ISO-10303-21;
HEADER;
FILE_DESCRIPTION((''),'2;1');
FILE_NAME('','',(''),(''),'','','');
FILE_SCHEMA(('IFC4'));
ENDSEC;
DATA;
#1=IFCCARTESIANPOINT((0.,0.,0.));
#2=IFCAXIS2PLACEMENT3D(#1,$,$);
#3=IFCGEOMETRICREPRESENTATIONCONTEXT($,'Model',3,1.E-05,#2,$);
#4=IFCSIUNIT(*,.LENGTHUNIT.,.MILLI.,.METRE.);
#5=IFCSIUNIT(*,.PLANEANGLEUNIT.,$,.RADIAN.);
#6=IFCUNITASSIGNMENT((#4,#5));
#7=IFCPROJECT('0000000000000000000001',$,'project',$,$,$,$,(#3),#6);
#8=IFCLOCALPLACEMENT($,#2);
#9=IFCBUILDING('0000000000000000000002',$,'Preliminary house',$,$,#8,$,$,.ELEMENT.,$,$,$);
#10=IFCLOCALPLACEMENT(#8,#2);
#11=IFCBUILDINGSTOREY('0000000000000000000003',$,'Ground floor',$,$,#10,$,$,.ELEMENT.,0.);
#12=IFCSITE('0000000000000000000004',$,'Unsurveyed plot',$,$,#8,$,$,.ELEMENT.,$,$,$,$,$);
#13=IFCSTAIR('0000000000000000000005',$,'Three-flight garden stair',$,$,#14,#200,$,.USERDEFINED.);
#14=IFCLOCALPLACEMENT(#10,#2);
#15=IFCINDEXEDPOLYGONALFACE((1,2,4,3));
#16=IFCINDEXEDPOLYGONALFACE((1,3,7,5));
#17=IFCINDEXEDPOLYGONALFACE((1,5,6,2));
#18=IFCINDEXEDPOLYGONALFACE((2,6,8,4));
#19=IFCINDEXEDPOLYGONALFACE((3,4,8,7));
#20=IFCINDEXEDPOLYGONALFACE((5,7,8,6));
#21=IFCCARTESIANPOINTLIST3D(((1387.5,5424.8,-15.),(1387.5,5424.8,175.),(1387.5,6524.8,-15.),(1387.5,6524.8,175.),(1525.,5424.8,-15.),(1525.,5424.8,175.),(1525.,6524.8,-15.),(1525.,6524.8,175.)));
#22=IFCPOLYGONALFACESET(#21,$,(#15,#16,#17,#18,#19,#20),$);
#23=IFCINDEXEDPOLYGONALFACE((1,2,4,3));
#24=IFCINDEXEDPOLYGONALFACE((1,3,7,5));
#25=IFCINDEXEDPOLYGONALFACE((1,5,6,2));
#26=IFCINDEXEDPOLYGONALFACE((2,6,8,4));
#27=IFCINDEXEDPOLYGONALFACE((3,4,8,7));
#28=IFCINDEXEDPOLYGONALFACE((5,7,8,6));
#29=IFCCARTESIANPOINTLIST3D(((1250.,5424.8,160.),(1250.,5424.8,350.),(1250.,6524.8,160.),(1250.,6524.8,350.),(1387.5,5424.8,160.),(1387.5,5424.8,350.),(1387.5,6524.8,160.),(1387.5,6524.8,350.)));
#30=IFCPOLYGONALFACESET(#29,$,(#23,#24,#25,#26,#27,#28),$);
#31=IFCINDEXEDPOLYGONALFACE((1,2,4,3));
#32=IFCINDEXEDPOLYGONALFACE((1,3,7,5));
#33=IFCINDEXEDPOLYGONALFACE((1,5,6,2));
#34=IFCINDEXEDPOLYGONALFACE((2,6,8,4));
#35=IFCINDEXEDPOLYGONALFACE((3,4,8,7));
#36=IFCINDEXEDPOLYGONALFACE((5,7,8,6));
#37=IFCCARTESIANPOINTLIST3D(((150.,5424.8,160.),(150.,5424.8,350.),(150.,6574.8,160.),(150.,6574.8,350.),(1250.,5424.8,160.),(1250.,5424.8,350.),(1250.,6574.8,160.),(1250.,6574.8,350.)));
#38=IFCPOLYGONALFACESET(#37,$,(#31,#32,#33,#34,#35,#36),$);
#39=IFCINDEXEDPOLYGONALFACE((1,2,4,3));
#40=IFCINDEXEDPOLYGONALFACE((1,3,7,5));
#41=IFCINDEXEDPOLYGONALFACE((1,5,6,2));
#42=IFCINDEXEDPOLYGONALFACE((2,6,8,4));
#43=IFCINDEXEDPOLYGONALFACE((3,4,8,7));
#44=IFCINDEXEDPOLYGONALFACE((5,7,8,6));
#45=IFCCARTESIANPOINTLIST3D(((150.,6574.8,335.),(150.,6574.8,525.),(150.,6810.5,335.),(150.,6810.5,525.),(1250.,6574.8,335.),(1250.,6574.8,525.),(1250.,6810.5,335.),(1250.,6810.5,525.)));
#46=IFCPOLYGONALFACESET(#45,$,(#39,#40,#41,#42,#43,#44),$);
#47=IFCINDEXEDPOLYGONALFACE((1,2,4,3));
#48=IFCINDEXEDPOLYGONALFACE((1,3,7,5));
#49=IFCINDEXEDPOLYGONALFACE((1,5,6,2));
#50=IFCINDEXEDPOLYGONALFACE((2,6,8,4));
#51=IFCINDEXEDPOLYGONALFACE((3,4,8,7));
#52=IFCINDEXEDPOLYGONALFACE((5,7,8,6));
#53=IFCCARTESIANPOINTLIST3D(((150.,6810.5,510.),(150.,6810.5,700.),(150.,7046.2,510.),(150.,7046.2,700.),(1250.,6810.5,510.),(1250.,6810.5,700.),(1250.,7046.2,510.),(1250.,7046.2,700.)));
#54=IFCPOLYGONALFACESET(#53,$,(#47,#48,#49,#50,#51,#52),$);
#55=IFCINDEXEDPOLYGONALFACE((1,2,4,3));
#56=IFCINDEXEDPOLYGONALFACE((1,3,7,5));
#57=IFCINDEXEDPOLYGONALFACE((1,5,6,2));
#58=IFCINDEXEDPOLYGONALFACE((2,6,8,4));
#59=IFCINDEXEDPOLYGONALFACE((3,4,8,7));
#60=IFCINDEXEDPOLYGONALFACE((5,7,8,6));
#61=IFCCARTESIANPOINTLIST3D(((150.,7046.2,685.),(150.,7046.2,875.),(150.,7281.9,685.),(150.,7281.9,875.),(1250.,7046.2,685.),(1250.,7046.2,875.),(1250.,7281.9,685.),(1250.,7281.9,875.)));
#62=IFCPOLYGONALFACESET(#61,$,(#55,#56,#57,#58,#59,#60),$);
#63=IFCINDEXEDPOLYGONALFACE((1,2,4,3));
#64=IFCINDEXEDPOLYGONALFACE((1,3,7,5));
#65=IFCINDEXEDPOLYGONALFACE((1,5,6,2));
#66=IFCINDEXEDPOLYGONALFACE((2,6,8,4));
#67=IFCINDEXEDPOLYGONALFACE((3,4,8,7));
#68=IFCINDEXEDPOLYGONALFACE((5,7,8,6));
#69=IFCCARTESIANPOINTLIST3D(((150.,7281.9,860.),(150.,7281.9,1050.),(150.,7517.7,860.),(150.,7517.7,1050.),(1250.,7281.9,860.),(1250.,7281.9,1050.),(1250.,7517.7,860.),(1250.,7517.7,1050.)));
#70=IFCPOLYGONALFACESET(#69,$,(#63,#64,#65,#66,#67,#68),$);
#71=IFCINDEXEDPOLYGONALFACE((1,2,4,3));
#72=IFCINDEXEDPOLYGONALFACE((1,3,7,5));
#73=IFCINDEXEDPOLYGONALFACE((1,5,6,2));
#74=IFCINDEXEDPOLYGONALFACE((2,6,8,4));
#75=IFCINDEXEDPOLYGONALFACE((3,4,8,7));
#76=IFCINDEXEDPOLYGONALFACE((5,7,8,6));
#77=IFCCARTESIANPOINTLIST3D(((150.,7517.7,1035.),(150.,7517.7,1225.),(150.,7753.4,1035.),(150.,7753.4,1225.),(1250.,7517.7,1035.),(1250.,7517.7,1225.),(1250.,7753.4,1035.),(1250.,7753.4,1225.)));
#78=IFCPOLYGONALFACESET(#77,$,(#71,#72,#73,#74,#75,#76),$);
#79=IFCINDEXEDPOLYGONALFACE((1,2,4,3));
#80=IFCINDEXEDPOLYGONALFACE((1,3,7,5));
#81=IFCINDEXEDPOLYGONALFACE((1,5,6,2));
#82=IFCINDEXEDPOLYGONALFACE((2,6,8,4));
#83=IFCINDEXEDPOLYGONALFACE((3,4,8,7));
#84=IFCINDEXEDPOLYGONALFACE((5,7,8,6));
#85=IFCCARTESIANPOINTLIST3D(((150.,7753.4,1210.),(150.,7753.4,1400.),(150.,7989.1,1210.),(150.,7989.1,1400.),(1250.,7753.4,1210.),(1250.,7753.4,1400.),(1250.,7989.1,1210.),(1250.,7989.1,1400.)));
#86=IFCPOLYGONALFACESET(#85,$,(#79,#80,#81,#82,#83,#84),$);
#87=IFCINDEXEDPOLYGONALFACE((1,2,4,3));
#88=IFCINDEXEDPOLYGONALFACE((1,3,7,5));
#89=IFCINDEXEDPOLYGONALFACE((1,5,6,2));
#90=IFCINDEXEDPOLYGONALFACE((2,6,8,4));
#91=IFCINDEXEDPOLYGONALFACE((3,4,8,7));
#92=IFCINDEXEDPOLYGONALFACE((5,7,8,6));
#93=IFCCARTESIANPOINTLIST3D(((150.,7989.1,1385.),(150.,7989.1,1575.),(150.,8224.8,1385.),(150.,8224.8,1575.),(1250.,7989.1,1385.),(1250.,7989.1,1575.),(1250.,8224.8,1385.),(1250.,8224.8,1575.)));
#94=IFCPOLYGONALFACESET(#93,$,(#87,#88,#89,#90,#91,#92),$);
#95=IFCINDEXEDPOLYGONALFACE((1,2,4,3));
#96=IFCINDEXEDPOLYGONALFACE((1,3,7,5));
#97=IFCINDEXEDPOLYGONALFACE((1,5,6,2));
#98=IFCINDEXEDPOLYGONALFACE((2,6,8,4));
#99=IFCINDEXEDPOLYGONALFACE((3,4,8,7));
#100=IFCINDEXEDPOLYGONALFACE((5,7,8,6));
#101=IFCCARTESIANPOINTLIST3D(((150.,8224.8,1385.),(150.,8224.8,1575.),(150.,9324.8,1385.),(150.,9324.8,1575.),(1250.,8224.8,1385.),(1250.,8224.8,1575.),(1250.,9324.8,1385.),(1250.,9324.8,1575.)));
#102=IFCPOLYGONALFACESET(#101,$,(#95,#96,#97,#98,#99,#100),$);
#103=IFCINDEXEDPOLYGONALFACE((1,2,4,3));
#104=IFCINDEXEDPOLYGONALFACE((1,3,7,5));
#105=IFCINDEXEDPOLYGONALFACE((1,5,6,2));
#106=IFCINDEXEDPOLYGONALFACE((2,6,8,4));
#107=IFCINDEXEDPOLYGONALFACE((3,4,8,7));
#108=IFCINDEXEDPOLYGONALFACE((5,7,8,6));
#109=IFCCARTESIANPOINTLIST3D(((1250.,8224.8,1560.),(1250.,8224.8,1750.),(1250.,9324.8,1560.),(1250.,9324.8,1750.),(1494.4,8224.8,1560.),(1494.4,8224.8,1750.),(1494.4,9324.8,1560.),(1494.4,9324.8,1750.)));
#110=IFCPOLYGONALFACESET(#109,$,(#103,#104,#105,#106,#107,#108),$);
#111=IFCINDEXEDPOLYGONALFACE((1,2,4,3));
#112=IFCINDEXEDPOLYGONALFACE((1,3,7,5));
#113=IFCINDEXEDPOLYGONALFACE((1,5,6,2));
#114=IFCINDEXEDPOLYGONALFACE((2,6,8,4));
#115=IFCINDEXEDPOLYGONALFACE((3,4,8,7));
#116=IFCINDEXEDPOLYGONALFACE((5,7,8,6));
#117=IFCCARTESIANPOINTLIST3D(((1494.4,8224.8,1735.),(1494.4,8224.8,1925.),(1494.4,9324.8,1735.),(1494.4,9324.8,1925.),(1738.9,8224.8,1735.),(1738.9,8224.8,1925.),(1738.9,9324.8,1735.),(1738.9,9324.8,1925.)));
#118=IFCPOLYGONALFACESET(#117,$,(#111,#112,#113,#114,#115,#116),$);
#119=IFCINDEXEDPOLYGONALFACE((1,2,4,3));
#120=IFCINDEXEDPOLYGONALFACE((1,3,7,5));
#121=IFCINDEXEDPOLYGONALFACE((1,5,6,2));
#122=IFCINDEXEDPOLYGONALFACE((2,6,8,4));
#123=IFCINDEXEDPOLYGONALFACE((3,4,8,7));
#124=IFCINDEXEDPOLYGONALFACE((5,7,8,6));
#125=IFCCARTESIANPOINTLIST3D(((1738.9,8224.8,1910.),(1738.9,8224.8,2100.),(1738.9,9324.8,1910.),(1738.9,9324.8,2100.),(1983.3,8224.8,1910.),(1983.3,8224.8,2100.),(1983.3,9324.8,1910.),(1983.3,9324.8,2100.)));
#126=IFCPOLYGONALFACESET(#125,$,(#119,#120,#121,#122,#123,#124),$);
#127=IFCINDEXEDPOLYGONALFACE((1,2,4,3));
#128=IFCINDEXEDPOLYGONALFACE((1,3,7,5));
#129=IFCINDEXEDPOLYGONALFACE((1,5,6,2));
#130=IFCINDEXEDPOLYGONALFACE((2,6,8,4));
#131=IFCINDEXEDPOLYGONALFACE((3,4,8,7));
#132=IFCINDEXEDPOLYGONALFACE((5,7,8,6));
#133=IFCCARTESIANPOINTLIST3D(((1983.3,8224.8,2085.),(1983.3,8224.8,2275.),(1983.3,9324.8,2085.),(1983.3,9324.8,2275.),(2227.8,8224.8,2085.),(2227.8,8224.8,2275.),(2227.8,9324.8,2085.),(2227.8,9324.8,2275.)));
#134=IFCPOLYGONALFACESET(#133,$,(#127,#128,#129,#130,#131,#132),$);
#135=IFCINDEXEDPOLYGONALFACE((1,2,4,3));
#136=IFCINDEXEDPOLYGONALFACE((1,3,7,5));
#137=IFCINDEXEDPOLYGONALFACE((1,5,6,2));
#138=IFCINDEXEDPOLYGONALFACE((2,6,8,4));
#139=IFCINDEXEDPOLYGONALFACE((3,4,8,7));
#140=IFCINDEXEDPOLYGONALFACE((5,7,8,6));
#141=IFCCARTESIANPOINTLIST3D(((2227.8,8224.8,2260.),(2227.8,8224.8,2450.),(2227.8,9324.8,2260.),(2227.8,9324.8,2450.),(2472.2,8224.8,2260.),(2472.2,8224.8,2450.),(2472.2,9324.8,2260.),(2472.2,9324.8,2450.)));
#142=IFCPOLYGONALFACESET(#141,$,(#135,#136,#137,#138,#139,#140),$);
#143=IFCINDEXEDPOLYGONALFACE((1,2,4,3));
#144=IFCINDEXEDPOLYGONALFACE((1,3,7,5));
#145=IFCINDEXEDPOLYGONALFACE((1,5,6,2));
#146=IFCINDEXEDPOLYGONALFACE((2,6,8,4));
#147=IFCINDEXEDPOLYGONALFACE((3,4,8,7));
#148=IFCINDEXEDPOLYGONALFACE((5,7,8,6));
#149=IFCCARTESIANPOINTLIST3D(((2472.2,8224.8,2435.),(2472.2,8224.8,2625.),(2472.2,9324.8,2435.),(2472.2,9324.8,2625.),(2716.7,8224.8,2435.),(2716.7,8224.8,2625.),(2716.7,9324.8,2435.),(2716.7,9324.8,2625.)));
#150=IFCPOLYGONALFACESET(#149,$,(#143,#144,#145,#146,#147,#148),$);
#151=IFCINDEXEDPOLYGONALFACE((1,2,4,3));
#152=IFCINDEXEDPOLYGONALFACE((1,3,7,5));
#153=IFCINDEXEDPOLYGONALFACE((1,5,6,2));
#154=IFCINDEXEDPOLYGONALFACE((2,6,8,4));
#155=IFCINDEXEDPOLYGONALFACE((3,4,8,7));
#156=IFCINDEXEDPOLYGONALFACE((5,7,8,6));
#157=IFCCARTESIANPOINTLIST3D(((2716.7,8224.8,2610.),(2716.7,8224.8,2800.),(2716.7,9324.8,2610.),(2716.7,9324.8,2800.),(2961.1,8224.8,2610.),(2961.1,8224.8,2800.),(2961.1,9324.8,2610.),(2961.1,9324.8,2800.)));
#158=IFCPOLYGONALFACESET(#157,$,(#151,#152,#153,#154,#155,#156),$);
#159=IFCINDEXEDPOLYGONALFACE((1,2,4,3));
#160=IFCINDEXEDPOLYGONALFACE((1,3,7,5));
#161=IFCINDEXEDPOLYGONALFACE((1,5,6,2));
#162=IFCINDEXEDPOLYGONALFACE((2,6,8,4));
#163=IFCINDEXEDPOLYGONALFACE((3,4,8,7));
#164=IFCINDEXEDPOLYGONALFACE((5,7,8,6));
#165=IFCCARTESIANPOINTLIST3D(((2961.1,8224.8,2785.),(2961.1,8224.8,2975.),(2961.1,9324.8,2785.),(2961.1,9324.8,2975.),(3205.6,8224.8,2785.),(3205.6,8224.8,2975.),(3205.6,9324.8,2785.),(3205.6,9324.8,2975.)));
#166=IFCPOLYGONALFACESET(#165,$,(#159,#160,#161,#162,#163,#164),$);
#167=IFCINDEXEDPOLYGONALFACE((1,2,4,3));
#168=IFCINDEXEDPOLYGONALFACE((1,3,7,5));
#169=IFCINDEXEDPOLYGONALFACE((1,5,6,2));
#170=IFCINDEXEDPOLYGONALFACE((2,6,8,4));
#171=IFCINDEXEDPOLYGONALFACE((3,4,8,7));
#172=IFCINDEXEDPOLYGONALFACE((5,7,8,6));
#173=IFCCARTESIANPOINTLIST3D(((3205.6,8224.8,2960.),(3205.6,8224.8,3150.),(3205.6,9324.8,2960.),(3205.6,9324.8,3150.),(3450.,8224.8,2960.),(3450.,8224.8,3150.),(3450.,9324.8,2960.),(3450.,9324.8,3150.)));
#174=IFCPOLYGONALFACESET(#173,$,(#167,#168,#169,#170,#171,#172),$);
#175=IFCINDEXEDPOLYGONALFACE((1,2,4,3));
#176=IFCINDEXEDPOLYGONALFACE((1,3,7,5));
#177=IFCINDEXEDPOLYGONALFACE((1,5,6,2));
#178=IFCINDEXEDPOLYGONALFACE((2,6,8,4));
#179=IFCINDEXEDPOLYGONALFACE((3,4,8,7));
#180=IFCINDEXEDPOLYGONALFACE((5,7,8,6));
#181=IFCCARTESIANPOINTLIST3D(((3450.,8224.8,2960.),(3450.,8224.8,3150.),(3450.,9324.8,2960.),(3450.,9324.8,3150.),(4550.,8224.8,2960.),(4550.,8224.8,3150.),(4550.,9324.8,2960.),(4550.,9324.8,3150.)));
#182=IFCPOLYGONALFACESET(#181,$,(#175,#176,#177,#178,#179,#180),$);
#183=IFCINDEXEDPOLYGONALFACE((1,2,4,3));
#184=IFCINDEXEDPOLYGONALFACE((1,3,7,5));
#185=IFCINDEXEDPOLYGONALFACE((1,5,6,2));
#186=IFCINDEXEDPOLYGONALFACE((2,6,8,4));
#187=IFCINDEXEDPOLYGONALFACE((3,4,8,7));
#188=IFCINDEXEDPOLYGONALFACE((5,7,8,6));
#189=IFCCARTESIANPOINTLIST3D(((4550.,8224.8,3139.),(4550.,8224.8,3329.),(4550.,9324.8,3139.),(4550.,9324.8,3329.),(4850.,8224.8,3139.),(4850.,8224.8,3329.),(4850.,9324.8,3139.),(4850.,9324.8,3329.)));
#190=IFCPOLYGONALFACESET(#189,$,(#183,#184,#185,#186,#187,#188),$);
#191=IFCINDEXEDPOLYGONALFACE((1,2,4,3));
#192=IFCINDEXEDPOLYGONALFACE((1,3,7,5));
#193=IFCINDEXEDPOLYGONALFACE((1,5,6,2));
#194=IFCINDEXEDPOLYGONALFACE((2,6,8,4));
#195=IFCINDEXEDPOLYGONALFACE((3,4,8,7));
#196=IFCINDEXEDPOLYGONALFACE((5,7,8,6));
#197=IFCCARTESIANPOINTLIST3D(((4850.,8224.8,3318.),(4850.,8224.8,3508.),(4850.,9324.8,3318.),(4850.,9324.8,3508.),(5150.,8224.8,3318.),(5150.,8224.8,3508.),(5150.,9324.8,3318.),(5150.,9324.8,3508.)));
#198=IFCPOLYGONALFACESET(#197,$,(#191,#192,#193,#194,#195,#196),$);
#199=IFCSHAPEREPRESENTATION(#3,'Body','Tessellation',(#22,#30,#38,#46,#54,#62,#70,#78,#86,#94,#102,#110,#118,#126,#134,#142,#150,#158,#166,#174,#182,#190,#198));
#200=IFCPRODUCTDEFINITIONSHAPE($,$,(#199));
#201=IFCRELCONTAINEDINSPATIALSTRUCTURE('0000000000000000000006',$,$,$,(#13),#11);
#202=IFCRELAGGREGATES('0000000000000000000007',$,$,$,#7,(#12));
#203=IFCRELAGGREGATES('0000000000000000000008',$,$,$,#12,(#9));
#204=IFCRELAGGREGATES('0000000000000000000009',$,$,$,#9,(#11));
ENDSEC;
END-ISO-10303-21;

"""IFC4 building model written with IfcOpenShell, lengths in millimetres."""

from ifc_helpers import new_model, si_unit, frame, origin, place, context, project, spatial, polyline, outline, extrude, element, save


model = new_model("IFC4")

# Units and contexts
model_context = context("Model", 3, precision=1e-05, world=origin())
ifc_project = project(units=[si_unit("LENGTHUNIT", "METRE", prefix="MILLI"), si_unit("PLANEANGLEUNIT", "RADIAN")], contexts=[model_context])

# Site, building, storey
placement_1 = place(None, origin())
site = spatial("IfcSite", under=ifc_project, at=placement_1, Name="Unsurveyed plot", CompositionType="ELEMENT")
building = spatial("IfcBuilding", under=site, at=placement_1, Name="Preliminary house", CompositionType="ELEMENT")
placement_2 = place(placement_1, origin())
storey = spatial("IfcBuildingStorey", under=building, at=placement_2, Name="Ground floor", CompositionType="ELEMENT", Elevation=0.0)

# Stair
element("IfcStair", 1, at=placement_2, inside=storey, Name="Three-flight garden stair", PredefinedType="USERDEFINED", context=model_context, shape_type="SweptSolid", body=[
    extrude(outline(polyline([(1525.0, 5424.8), (1525.0, 6524.8), (1387.5, 6524.8), (1387.5, 5424.8), (1525.0, 5424.8)])), frame((0.0, 0.0, -15.0)), (0.0, 0.0, 1.0), 190.0),
    extrude(outline(polyline([(1387.5, 5424.8), (1387.5, 6524.8), (1250.0, 6524.8), (1250.0, 5424.8), (1387.5, 5424.8)])), frame((0.0, 0.0, 160.0)), (0.0, 0.0, 1.0), 190.0),
    extrude(outline(polyline([(1250.0, 5424.8), (1250.0, 6574.8), (150.0, 6574.8), (150.0, 5424.8), (1250.0, 5424.8)])), frame((0.0, 0.0, 160.0)), (0.0, 0.0, 1.0), 190.0),
    extrude(outline(polyline([(1250.0, 6574.8), (1250.0, 6810.5), (150.0, 6810.5), (150.0, 6574.8), (1250.0, 6574.8)])), frame((0.0, 0.0, 335.0)), (0.0, 0.0, 1.0), 190.0),
    extrude(outline(polyline([(1250.0, 6810.5), (1250.0, 7046.2), (150.0, 7046.2), (150.0, 6810.5), (1250.0, 6810.5)])), frame((0.0, 0.0, 510.0)), (0.0, 0.0, 1.0), 190.0),
    extrude(outline(polyline([(1250.0, 7046.2), (1250.0, 7281.9), (150.0, 7281.9), (150.0, 7046.2), (1250.0, 7046.2)])), frame((0.0, 0.0, 685.0)), (0.0, 0.0, 1.0), 190.0),
    extrude(outline(polyline([(1250.0, 7281.9), (1250.0, 7517.7), (150.0, 7517.7), (150.0, 7281.9), (1250.0, 7281.9)])), frame((0.0, 0.0, 860.0)), (0.0, 0.0, 1.0), 190.0),
    extrude(outline(polyline([(1250.0, 7517.7), (1250.0, 7753.4), (150.0, 7753.4), (150.0, 7517.7), (1250.0, 7517.7)])), frame((0.0, 0.0, 1035.0)), (0.0, 0.0, 1.0), 190.0),
    extrude(outline(polyline([(1250.0, 7753.4), (1250.0, 7989.1), (150.0, 7989.1), (150.0, 7753.4), (1250.0, 7753.4)])), frame((0.0, 0.0, 1210.0)), (0.0, 0.0, 1.0), 190.0),
    extrude(outline(polyline([(1250.0, 7989.1), (1250.0, 8224.8), (150.0, 8224.8), (150.0, 7989.1), (1250.0, 7989.1)])), frame((0.0, 0.0, 1385.0)), (0.0, 0.0, 1.0), 190.0),
    extrude(outline(polyline([(1250.0, 8224.8), (1250.0, 9324.8), (150.0, 9324.8), (150.0, 8224.8), (1250.0, 8224.8)])), frame((0.0, 0.0, 1385.0)), (0.0, 0.0, 1.0), 190.0),
    extrude(outline(polyline([(1494.4, 8224.8), (1494.4, 9324.8), (1250.0, 9324.8), (1250.0, 8224.8), (1494.4, 8224.8)])), frame((0.0, 0.0, 1560.0)), (0.0, 0.0, 1.0), 190.0),
    extrude(outline(polyline([(1738.9, 8224.8), (1738.9, 9324.8), (1494.4, 9324.8), (1494.4, 8224.8), (1738.9, 8224.8)])), frame((0.0, 0.0, 1735.0)), (0.0, 0.0, 1.0), 190.0),
    extrude(outline(polyline([(1983.3, 8224.8), (1983.3, 9324.8), (1738.9, 9324.8), (1738.9, 8224.8), (1983.3, 8224.8)])), frame((0.0, 0.0, 1910.0)), (0.0, 0.0, 1.0), 190.0),
    extrude(outline(polyline([(2227.8, 8224.8), (2227.8, 9324.8), (1983.3, 9324.8), (1983.3, 8224.8), (2227.8, 8224.8)])), frame((0.0, 0.0, 2085.0)), (0.0, 0.0, 1.0), 190.0),
    extrude(outline(polyline([(2472.2, 8224.8), (2472.2, 9324.8), (2227.8, 9324.8), (2227.8, 8224.8), (2472.2, 8224.8)])), frame((0.0, 0.0, 2260.0)), (0.0, 0.0, 1.0), 190.0),
    extrude(outline(polyline([(2716.7, 8224.8), (2716.7, 9324.8), (2472.2, 9324.8), (2472.2, 8224.8), (2716.7, 8224.8)])), frame((0.0, 0.0, 2435.0)), (0.0, 0.0, 1.0), 190.0),
    extrude(outline(polyline([(2961.1, 8224.8), (2961.1, 9324.8), (2716.7, 9324.8), (2716.7, 8224.8), (2961.1, 8224.8)])), frame((0.0, 0.0, 2610.0)), (0.0, 0.0, 1.0), 190.0),
    extrude(outline(polyline([(3205.6, 8224.8), (3205.6, 9324.8), (2961.1, 9324.8), (2961.1, 8224.8), (3205.6, 8224.8)])), frame((0.0, 0.0, 2785.0)), (0.0, 0.0, 1.0), 190.0),
    extrude(outline(polyline([(3450.0, 8224.8), (3450.0, 9324.8), (3205.6, 9324.8), (3205.6, 8224.8), (3450.0, 8224.8)])), frame((0.0, 0.0, 2960.0)), (0.0, 0.0, 1.0), 190.0),
    extrude(outline(polyline([(4550.0, 8224.8), (4550.0, 9324.8), (3450.0, 9324.8), (3450.0, 8224.8), (4550.0, 8224.8)])), frame((0.0, 0.0, 2960.0)), (0.0, 0.0, 1.0), 190.0),
    extrude(outline(polyline([(4850.0, 8224.8), (4850.0, 9324.8), (4550.0, 9324.8), (4550.0, 8224.8), (4850.0, 8224.8)])), frame((0.0, 0.0, 3139.0)), (0.0, 0.0, 1.0), 190.0),
    extrude(outline(polyline([(5150.0, 8224.8), (5150.0, 9324.8), (4850.0, 9324.8), (4850.0, 8224.8), (5150.0, 8224.8)])), frame((0.0, 0.0, 3318.0)), (0.0, 0.0, 1.0), 190.0),
])

save(model, "model.ifc")
